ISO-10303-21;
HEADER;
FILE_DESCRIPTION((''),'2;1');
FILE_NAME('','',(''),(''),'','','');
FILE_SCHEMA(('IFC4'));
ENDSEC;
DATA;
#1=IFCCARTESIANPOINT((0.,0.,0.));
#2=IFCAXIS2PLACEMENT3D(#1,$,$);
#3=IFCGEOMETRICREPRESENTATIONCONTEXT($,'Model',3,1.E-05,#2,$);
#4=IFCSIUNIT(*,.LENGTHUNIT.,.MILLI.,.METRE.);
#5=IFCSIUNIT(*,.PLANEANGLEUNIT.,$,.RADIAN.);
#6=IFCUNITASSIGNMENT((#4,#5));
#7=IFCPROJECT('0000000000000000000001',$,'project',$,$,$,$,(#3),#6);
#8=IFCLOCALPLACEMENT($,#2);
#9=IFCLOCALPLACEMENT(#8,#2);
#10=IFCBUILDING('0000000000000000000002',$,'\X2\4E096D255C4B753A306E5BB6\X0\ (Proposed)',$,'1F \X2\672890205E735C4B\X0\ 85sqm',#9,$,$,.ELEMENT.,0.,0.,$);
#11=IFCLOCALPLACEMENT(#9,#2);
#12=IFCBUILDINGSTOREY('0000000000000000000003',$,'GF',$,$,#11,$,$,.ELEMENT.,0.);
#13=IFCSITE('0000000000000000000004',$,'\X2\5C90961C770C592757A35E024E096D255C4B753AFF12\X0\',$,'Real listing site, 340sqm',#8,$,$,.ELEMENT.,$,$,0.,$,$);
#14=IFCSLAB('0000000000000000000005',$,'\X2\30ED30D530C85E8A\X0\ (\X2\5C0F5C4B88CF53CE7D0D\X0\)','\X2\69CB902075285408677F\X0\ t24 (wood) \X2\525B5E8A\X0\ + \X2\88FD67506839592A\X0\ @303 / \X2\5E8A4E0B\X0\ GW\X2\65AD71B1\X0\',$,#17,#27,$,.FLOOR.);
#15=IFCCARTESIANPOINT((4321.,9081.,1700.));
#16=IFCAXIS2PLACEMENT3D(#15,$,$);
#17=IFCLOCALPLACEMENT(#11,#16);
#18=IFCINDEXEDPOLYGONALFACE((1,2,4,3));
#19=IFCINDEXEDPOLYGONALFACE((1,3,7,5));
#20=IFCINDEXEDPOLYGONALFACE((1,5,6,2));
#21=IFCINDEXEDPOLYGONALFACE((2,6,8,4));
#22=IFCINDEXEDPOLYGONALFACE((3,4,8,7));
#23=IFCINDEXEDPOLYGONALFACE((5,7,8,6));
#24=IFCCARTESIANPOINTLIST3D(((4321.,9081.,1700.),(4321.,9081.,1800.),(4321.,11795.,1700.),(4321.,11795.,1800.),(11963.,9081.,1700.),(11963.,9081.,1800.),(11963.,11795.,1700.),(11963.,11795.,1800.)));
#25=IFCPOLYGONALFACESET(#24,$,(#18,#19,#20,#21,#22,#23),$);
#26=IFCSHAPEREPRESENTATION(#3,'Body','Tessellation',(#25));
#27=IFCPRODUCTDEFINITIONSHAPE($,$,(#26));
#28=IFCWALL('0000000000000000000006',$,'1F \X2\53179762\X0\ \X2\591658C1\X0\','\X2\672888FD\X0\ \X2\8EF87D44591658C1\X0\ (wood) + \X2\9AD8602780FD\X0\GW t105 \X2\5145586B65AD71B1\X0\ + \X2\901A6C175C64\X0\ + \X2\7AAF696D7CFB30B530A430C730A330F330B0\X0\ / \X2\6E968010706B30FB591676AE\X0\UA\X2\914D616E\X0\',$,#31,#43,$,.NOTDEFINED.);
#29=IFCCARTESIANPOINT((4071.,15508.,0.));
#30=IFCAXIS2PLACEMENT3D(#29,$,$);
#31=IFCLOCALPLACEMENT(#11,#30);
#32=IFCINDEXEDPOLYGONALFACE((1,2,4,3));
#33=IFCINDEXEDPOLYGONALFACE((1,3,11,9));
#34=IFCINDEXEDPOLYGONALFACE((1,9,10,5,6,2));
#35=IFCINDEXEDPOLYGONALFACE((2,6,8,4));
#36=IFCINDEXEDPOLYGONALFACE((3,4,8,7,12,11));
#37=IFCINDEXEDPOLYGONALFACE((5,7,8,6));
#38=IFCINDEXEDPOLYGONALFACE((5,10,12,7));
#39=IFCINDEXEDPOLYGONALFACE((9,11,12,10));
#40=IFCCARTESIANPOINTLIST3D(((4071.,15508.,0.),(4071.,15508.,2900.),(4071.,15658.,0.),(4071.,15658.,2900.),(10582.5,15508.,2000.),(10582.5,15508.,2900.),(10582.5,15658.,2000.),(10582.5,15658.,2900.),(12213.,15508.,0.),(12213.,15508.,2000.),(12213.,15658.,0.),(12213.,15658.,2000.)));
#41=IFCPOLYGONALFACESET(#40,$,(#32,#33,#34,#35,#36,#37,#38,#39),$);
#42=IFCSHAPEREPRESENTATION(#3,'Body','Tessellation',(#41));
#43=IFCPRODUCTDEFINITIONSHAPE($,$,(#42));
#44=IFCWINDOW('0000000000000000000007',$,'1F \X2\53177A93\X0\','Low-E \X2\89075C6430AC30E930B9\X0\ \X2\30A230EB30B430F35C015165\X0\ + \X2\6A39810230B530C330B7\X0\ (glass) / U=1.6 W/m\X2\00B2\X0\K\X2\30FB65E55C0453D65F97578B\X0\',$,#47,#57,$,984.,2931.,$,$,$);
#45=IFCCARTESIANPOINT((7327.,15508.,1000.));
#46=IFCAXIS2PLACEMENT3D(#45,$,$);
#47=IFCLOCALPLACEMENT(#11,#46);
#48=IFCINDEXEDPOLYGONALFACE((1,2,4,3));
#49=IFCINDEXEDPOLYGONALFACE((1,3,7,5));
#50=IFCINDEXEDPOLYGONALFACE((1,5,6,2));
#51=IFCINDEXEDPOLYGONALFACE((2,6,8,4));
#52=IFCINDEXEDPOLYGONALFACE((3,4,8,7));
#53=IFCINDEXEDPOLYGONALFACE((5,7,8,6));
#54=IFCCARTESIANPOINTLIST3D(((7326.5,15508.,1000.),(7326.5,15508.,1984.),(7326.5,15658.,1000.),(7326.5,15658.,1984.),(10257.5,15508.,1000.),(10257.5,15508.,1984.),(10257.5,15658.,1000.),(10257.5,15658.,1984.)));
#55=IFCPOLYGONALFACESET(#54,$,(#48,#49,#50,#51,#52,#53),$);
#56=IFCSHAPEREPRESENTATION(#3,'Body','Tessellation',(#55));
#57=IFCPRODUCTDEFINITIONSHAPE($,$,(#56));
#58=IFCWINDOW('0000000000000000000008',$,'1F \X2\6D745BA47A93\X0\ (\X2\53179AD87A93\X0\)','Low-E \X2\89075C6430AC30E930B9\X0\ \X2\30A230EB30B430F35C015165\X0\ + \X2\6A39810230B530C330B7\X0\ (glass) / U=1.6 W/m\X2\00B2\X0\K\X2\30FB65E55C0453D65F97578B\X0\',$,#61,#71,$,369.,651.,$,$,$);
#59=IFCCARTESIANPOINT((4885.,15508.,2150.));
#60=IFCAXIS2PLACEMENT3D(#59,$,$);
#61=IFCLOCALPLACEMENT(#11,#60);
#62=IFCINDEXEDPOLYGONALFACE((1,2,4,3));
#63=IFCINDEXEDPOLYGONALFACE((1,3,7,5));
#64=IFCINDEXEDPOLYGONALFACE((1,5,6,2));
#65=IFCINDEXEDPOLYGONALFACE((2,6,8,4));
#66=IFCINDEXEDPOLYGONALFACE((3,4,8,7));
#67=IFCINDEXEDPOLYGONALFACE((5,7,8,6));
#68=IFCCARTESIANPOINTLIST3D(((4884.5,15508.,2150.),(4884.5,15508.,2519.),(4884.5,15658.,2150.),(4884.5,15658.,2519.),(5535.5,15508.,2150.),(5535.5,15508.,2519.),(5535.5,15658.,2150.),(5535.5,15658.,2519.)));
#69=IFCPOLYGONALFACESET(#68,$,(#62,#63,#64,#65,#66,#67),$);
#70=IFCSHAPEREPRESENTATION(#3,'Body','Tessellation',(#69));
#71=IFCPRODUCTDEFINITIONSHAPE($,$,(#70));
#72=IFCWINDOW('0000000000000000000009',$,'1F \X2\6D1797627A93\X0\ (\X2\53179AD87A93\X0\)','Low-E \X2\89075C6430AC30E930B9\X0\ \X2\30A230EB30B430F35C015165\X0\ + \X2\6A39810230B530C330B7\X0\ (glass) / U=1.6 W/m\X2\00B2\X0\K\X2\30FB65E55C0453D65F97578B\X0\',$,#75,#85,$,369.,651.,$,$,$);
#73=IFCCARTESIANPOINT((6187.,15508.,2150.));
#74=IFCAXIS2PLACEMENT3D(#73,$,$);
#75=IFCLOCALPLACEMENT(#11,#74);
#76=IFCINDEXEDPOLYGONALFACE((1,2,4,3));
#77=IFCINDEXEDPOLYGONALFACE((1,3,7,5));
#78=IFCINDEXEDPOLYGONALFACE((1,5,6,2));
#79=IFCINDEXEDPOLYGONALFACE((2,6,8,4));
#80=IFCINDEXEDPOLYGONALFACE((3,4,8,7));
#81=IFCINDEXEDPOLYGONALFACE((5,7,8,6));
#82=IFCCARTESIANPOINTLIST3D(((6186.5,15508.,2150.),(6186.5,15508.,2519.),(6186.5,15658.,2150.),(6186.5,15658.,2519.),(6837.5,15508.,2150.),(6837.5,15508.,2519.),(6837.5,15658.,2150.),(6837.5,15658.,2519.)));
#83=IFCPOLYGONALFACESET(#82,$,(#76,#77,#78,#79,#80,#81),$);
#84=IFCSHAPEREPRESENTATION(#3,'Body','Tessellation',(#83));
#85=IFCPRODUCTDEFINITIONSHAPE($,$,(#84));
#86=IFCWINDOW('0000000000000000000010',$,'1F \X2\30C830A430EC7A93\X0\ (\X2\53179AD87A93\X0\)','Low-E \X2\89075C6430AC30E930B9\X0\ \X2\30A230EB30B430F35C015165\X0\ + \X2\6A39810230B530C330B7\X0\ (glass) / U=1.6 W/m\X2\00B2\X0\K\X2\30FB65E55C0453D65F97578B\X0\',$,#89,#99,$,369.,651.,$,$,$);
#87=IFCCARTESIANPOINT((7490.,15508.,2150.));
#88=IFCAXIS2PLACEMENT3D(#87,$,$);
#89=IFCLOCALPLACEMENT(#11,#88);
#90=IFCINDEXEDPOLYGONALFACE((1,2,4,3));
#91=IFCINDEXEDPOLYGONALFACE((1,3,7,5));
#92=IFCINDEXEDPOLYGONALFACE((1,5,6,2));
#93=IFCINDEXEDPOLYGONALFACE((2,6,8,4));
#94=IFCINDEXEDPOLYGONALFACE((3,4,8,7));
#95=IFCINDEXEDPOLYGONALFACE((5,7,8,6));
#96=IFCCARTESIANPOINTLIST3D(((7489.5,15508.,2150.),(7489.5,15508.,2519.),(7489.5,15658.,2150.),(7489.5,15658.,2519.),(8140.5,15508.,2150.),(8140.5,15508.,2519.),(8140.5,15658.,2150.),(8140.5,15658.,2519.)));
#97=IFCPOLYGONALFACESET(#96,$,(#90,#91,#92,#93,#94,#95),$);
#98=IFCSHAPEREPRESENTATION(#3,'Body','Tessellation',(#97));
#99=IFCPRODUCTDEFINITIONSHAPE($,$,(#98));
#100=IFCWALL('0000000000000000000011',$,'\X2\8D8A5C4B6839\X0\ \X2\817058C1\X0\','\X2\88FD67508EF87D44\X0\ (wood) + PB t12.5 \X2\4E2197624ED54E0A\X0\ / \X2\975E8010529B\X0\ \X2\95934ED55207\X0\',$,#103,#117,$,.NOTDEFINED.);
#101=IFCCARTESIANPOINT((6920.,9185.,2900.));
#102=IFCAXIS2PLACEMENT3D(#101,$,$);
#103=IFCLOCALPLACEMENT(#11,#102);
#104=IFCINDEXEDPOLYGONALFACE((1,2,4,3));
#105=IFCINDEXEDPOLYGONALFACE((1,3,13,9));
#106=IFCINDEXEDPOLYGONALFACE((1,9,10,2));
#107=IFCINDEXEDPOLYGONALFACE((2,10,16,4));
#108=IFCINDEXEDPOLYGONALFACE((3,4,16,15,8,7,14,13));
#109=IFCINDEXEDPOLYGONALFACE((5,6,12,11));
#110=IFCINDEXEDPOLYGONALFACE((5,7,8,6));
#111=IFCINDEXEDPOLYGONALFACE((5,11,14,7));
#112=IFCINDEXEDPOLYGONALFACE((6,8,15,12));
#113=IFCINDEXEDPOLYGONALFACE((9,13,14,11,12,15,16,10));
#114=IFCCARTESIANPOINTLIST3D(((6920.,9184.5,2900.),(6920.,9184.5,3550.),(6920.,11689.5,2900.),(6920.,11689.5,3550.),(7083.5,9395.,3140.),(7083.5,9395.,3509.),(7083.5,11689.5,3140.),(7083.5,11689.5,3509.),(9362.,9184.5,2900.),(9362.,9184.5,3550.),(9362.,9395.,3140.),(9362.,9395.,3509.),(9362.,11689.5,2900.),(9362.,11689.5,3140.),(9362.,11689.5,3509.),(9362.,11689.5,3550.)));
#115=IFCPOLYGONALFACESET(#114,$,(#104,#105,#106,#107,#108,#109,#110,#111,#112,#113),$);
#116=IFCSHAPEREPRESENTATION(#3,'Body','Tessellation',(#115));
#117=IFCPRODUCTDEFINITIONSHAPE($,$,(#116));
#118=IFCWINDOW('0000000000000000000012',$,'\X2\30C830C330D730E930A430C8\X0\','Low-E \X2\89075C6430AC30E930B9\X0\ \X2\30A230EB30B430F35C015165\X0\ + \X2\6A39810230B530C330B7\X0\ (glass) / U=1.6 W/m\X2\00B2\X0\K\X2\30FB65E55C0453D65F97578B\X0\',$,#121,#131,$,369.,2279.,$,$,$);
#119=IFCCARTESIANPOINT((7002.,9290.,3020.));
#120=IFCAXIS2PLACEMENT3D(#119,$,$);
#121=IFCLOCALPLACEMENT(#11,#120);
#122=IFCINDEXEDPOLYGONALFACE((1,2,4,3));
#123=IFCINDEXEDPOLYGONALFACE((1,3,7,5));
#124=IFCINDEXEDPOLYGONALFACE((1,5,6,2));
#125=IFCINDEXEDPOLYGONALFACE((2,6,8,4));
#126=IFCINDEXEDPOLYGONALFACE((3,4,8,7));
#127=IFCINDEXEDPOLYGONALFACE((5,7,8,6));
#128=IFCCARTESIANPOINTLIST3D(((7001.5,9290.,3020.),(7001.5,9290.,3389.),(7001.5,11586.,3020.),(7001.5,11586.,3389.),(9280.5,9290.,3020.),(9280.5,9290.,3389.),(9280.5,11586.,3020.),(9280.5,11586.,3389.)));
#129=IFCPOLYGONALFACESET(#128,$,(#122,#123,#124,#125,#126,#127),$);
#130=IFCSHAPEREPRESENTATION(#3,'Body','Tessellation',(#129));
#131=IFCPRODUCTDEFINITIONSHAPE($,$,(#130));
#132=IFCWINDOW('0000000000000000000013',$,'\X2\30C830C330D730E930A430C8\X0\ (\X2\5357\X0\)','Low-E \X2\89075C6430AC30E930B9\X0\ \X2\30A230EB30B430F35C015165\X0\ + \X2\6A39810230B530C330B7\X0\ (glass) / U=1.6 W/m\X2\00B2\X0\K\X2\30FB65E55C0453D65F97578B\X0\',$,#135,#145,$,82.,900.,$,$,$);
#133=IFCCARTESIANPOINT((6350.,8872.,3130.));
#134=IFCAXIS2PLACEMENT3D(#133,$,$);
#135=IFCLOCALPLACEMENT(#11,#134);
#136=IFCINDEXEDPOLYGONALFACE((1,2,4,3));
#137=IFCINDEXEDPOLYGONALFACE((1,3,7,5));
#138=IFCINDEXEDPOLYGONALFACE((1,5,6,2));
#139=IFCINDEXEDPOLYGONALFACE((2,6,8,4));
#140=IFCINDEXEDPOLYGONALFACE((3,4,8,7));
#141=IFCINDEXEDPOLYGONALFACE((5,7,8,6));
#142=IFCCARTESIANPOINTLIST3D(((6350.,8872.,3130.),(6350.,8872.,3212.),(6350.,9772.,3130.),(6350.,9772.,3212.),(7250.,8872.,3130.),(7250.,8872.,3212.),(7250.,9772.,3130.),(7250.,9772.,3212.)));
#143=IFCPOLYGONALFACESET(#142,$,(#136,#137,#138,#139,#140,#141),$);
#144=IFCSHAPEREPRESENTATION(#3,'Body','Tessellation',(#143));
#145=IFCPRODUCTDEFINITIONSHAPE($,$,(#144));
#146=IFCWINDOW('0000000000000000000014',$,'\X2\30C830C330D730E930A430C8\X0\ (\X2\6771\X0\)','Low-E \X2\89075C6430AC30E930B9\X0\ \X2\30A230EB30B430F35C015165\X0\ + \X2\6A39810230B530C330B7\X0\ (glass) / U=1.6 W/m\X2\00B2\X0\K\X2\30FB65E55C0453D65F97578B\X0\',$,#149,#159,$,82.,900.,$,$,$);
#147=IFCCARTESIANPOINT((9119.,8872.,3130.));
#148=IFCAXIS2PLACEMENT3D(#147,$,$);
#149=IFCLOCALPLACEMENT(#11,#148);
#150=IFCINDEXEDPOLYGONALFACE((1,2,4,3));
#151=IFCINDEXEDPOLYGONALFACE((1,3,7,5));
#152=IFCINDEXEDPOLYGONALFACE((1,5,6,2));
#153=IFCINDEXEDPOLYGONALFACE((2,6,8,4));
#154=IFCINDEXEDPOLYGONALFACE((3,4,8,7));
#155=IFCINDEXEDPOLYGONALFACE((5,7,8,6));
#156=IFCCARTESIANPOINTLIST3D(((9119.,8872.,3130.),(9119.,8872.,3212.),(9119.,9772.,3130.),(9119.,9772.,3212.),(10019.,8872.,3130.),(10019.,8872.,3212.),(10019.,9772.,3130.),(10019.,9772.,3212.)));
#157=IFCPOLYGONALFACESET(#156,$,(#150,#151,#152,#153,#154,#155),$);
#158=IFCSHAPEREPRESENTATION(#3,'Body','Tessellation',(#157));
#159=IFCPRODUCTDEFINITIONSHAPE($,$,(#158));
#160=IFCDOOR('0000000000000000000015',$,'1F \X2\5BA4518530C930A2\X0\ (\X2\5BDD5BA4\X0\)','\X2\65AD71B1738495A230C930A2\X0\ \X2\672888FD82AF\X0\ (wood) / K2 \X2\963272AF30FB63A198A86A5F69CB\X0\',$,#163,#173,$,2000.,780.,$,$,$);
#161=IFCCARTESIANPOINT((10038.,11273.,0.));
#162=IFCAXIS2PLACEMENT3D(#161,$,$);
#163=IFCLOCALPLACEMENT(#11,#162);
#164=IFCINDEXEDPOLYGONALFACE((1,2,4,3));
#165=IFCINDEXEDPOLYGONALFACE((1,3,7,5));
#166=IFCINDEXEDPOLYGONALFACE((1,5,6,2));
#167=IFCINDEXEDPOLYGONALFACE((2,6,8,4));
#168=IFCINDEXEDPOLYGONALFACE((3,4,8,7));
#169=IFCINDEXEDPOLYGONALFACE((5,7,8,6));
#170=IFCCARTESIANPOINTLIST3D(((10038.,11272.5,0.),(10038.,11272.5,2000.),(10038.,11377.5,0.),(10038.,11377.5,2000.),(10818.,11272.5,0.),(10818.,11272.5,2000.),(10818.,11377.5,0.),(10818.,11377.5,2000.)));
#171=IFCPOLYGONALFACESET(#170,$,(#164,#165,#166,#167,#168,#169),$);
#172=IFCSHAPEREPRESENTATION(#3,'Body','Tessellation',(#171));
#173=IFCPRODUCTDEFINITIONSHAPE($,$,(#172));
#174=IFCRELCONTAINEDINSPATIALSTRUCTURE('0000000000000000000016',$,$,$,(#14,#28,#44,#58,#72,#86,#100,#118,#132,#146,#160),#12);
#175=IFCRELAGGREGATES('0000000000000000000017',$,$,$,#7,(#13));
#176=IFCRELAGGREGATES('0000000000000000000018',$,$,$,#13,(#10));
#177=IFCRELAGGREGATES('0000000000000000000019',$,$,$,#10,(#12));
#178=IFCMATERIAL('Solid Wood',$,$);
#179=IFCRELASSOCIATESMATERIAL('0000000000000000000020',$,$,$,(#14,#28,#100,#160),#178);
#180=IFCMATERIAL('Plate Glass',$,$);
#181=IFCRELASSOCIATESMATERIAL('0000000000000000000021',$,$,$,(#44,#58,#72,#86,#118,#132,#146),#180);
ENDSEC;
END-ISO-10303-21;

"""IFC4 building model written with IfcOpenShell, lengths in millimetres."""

from ifc_helpers import new_model, si_unit, frame, frame_2d, origin, place, context, project, spatial, rectangle, extrude, material, element, fill, save


model = new_model("IFC4")

# Units and contexts
model_context = context("Model", 3, precision=1e-05, world=origin())
ifc_project = project(units=[si_unit("LENGTHUNIT", "METRE", prefix="MILLI"), si_unit("PLANEANGLEUNIT", "RADIAN")], contexts=[model_context])

# Site, building, storey
site_placement = place(None, origin())
site = spatial("IfcSite", under=ifc_project, at=site_placement, Name="岐阜県大垣市三津屋町２", ObjectType="Real listing site, 340sqm", CompositionType="ELEMENT", RefElevation=0.0)
building_placement = place(site_placement, origin())
building = spatial("IfcBuilding", under=site, at=building_placement, Name="三津屋町の家 (Proposed)", ObjectType="1F 木造平屋 85sqm", CompositionType="ELEMENT", ElevationOfRefHeight=0.0, ElevationOfTerrain=0.0)
storey_placement = place(building_placement, origin())
storey = spatial("IfcBuildingStorey", under=building, at=storey_placement, Name="GF", CompositionType="ELEMENT", Elevation=0.0)

# Slab
ifc_material_1 = material(Name="Solid Wood")
slab_placement = place(storey_placement, frame((4321.0, 9081.0, 1700.0)))
element("IfcSlab", 1, at=slab_placement, inside=storey, material=ifc_material_1, Name="ロフト床 (小屋裏収納)", Description="構造用合板 t24 (wood) 剛床 + 製材根太 @303 / 床下 GW断熱", PredefinedType="FLOOR", context=model_context, shape_type="SweptSolid", body=[
    extrude(rectangle(XDim=7642.0, YDim=2714.0, at=frame_2d((3821.0, 1357.0))), frame((4321.0, 9081.0, 1700.0)), (0.0, 0.0, 1.0), 100.0),
])

# Wall, openings, windows
wall_1_placement = place(storey_placement, frame((4071.0, 15508.0, 0.0)))
wall_1 = element("IfcWall", 2, at=wall_1_placement, inside=storey, material=ifc_material_1, Name="1F 北面 外壁", Description="木製 軸組外壁 (wood) + 高性能GW t105 充填断熱 + 通気層 + 窯業系サイディング / 準耐火・外皮UA配慮", PredefinedType="NOTDEFINED", context=model_context, shape_type="SweptSolid", body=[
    extrude(rectangle(XDim=8142.0, YDim=150.0, at=frame_2d((4071.0, 75.0))), frame((4071.0, 15508.0, 0.0)), (0.0, 0.0, 1.0), 2900.0),
])
opening_1_placement = place(storey_placement, frame((7327.0, 15508.0, 1000.0)))
opening_1 = element("IfcOpeningElement", 3, at=opening_1_placement, cuts=wall_1, PredefinedType="NOTDEFINED", context=model_context, shape_type="SweptSolid", body=[
    extrude(rectangle(XDim=2931.0, YDim=150.0, at=frame_2d((1465.0, 75.0))), frame((7327.0, 15508.0, 1000.0)), (0.0, 0.0, 1.0), 984.0),
])
opening_2_placement = place(storey_placement, frame((4885.0, 15508.0, 2150.0)))
opening_2 = element("IfcOpeningElement", 4, at=opening_2_placement, cuts=wall_1, PredefinedType="NOTDEFINED", context=model_context, shape_type="SweptSolid", body=[
    extrude(rectangle(XDim=651.0, YDim=150.0, at=frame_2d((325.0, 75.0))), frame((4885.0, 15508.0, 2150.0)), (0.0, 0.0, 1.0), 369.0),
])
opening_3_placement = place(storey_placement, frame((6187.0, 15508.0, 2150.0)))
opening_3 = element("IfcOpeningElement", 5, at=opening_3_placement, cuts=wall_1, PredefinedType="NOTDEFINED", context=model_context, shape_type="SweptSolid", body=[
    extrude(rectangle(XDim=651.0, YDim=150.0, at=frame_2d((325.0, 75.0))), frame((6187.0, 15508.0, 2150.0)), (0.0, 0.0, 1.0), 369.0),
])
opening_4_placement = place(storey_placement, frame((7490.0, 15508.0, 2150.0)))
opening_4 = element("IfcOpeningElement", 6, at=opening_4_placement, cuts=wall_1, PredefinedType="NOTDEFINED", context=model_context, shape_type="SweptSolid", body=[
    extrude(rectangle(XDim=651.0, YDim=150.0, at=frame_2d((325.0, 75.0))), frame((7490.0, 15508.0, 2150.0)), (0.0, 0.0, 1.0), 369.0),
])
ifc_material_2 = material(Name="Plate Glass")
window_1_placement = place(storey_placement, frame((7327.0, 15508.0, 1000.0)))
window_1 = element("IfcWindow", 7, at=window_1_placement, inside=storey, material=ifc_material_2, Name="1F 北窓", Description="Low-E 複層ガラス アルゴン封入 + 樹脂サッシ (glass) / U=1.6 W/m²K・日射取得型", OverallHeight=984.0, OverallWidth=2931.0, context=model_context, shape_type="SweptSolid", body=[
    extrude(rectangle(XDim=2931.0, YDim=150.0, at=frame_2d((1465.0, 75.0))), frame((7327.0, 15508.0, 1000.0)), (0.0, 0.0, 1.0), 984.0),
])
fill(opening_1, window_1)
window_2_placement = place(storey_placement, frame((4885.0, 15508.0, 2150.0)))
window_2 = element("IfcWindow", 8, at=window_2_placement, inside=storey, material=ifc_material_2, Name="1F 浴室窓 (北高窓)", Description="Low-E 複層ガラス アルゴン封入 + 樹脂サッシ (glass) / U=1.6 W/m²K・日射取得型", OverallHeight=369.0, OverallWidth=651.0, context=model_context, shape_type="SweptSolid", body=[
    extrude(rectangle(XDim=651.0, YDim=150.0, at=frame_2d((325.0, 75.0))), frame((4885.0, 15508.0, 2150.0)), (0.0, 0.0, 1.0), 369.0),
])
fill(opening_2, window_2)
window_3_placement = place(storey_placement, frame((6187.0, 15508.0, 2150.0)))
window_3 = element("IfcWindow", 9, at=window_3_placement, inside=storey, material=ifc_material_2, Name="1F 洗面窓 (北高窓)", Description="Low-E 複層ガラス アルゴン封入 + 樹脂サッシ (glass) / U=1.6 W/m²K・日射取得型", OverallHeight=369.0, OverallWidth=651.0, context=model_context, shape_type="SweptSolid", body=[
    extrude(rectangle(XDim=651.0, YDim=150.0, at=frame_2d((325.0, 75.0))), frame((6187.0, 15508.0, 2150.0)), (0.0, 0.0, 1.0), 369.0),
])
fill(opening_3, window_3)
window_4_placement = place(storey_placement, frame((7490.0, 15508.0, 2150.0)))
window_4 = element("IfcWindow", 10, at=window_4_placement, inside=storey, material=ifc_material_2, Name="1F トイレ窓 (北高窓)", Description="Low-E 複層ガラス アルゴン封入 + 樹脂サッシ (glass) / U=1.6 W/m²K・日射取得型", OverallHeight=369.0, OverallWidth=651.0, context=model_context, shape_type="SweptSolid", body=[
    extrude(rectangle(XDim=651.0, YDim=150.0, at=frame_2d((325.0, 75.0))), frame((7490.0, 15508.0, 2150.0)), (0.0, 0.0, 1.0), 369.0),
])
fill(opening_4, window_4)

# Wall, openings, windows
wall_2_placement = place(storey_placement, frame((6920.0, 9185.0, 2900.0)))
wall_2 = element("IfcWall", 11, at=wall_2_placement, inside=storey, material=ifc_material_1, Name="越屋根 腰壁", Description="製材軸組 (wood) + PB t12.5 両面仕上 / 非耐力 間仕切", PredefinedType="NOTDEFINED", context=model_context, shape_type="SweptSolid", body=[
    extrude(rectangle(XDim=2442.0, YDim=2505.0, at=frame_2d((1221.0, 1252.0))), frame((6920.0, 9185.0, 2900.0)), (0.0, 0.0, 1.0), 650.0),
])
opening_5_placement = place(storey_placement, frame((7002.0, 9290.0, 3020.0)))
opening_5 = element("IfcOpeningElement", 12, at=opening_5_placement, cuts=wall_2, PredefinedType="NOTDEFINED", context=model_context, shape_type="SweptSolid", body=[
    extrude(rectangle(XDim=2279.0, YDim=2296.0, at=frame_2d((1139.0, 1148.0))), frame((7002.0, 9290.0, 3020.0)), (0.0, 0.0, 1.0), 369.0),
])
opening_6_placement = place(storey_placement, frame((6350.0, 8872.0, 3130.0)))
opening_6 = element("IfcOpeningElement", 13, at=opening_6_placement, cuts=wall_2, PredefinedType="NOTDEFINED", context=model_context, shape_type="SweptSolid", body=[
    extrude(rectangle(XDim=900.0, YDim=900.0, at=frame_2d((450.0, 450.0))), frame((6350.0, 8872.0, 3130.0)), (0.0, 0.0, 1.0), 82.0),
])
opening_7_placement = place(storey_placement, frame((9119.0, 8872.0, 3130.0)))
opening_7 = element("IfcOpeningElement", 14, at=opening_7_placement, cuts=wall_2, PredefinedType="NOTDEFINED", context=model_context, shape_type="SweptSolid", body=[
    extrude(rectangle(XDim=900.0, YDim=900.0, at=frame_2d((450.0, 450.0))), frame((9119.0, 8872.0, 3130.0)), (0.0, 0.0, 1.0), 82.0),
])
window_5_placement = place(storey_placement, frame((7002.0, 9290.0, 3020.0)))
window_5 = element("IfcWindow", 15, at=window_5_placement, inside=storey, material=ifc_material_2, Name="トップライト", Description="Low-E 複層ガラス アルゴン封入 + 樹脂サッシ (glass) / U=1.6 W/m²K・日射取得型", OverallHeight=369.0, OverallWidth=2279.0, context=model_context, shape_type="SweptSolid", body=[
    extrude(rectangle(XDim=2279.0, YDim=2296.0, at=frame_2d((1139.0, 1148.0))), frame((7002.0, 9290.0, 3020.0)), (0.0, 0.0, 1.0), 369.0),
])
fill(opening_5, window_5)
window_6_placement = place(storey_placement, frame((6350.0, 8872.0, 3130.0)))
window_6 = element("IfcWindow", 16, at=window_6_placement, inside=storey, material=ifc_material_2, Name="トップライト (南)", Description="Low-E 複層ガラス アルゴン封入 + 樹脂サッシ (glass) / U=1.6 W/m²K・日射取得型", OverallHeight=82.0, OverallWidth=900.0, context=model_context, shape_type="SweptSolid", body=[
    extrude(rectangle(XDim=900.0, YDim=900.0, at=frame_2d((450.0, 450.0))), frame((6350.0, 8872.0, 3130.0)), (0.0, 0.0, 1.0), 82.0),
])
fill(opening_6, window_6)
window_7_placement = place(storey_placement, frame((9119.0, 8872.0, 3130.0)))
window_7 = element("IfcWindow", 17, at=window_7_placement, inside=storey, material=ifc_material_2, Name="トップライト (東)", Description="Low-E 複層ガラス アルゴン封入 + 樹脂サッシ (glass) / U=1.6 W/m²K・日射取得型", OverallHeight=82.0, OverallWidth=900.0, context=model_context, shape_type="SweptSolid", body=[
    extrude(rectangle(XDim=900.0, YDim=900.0, at=frame_2d((450.0, 450.0))), frame((9119.0, 8872.0, 3130.0)), (0.0, 0.0, 1.0), 82.0),
])
fill(opening_7, window_7)

# Door
door_1_placement = place(storey_placement, frame((10038.0, 11273.0, 0.0)))
element("IfcDoor", 18, at=door_1_placement, inside=storey, material=ifc_material_1, Name="1F 室内ドア (寝室)", Description="断熱玄関ドア 木製芯 (wood) / K2 防犯・採風機構", OverallHeight=2000.0, OverallWidth=780.0, context=model_context, shape_type="SweptSolid", body=[
    extrude(rectangle(XDim=780.0, YDim=105.0, at=frame_2d((390.0, 52.0))), frame((10038.0, 11273.0, 0.0)), (0.0, 0.0, 1.0), 2000.0),
])

save(model, "model.ifc")
